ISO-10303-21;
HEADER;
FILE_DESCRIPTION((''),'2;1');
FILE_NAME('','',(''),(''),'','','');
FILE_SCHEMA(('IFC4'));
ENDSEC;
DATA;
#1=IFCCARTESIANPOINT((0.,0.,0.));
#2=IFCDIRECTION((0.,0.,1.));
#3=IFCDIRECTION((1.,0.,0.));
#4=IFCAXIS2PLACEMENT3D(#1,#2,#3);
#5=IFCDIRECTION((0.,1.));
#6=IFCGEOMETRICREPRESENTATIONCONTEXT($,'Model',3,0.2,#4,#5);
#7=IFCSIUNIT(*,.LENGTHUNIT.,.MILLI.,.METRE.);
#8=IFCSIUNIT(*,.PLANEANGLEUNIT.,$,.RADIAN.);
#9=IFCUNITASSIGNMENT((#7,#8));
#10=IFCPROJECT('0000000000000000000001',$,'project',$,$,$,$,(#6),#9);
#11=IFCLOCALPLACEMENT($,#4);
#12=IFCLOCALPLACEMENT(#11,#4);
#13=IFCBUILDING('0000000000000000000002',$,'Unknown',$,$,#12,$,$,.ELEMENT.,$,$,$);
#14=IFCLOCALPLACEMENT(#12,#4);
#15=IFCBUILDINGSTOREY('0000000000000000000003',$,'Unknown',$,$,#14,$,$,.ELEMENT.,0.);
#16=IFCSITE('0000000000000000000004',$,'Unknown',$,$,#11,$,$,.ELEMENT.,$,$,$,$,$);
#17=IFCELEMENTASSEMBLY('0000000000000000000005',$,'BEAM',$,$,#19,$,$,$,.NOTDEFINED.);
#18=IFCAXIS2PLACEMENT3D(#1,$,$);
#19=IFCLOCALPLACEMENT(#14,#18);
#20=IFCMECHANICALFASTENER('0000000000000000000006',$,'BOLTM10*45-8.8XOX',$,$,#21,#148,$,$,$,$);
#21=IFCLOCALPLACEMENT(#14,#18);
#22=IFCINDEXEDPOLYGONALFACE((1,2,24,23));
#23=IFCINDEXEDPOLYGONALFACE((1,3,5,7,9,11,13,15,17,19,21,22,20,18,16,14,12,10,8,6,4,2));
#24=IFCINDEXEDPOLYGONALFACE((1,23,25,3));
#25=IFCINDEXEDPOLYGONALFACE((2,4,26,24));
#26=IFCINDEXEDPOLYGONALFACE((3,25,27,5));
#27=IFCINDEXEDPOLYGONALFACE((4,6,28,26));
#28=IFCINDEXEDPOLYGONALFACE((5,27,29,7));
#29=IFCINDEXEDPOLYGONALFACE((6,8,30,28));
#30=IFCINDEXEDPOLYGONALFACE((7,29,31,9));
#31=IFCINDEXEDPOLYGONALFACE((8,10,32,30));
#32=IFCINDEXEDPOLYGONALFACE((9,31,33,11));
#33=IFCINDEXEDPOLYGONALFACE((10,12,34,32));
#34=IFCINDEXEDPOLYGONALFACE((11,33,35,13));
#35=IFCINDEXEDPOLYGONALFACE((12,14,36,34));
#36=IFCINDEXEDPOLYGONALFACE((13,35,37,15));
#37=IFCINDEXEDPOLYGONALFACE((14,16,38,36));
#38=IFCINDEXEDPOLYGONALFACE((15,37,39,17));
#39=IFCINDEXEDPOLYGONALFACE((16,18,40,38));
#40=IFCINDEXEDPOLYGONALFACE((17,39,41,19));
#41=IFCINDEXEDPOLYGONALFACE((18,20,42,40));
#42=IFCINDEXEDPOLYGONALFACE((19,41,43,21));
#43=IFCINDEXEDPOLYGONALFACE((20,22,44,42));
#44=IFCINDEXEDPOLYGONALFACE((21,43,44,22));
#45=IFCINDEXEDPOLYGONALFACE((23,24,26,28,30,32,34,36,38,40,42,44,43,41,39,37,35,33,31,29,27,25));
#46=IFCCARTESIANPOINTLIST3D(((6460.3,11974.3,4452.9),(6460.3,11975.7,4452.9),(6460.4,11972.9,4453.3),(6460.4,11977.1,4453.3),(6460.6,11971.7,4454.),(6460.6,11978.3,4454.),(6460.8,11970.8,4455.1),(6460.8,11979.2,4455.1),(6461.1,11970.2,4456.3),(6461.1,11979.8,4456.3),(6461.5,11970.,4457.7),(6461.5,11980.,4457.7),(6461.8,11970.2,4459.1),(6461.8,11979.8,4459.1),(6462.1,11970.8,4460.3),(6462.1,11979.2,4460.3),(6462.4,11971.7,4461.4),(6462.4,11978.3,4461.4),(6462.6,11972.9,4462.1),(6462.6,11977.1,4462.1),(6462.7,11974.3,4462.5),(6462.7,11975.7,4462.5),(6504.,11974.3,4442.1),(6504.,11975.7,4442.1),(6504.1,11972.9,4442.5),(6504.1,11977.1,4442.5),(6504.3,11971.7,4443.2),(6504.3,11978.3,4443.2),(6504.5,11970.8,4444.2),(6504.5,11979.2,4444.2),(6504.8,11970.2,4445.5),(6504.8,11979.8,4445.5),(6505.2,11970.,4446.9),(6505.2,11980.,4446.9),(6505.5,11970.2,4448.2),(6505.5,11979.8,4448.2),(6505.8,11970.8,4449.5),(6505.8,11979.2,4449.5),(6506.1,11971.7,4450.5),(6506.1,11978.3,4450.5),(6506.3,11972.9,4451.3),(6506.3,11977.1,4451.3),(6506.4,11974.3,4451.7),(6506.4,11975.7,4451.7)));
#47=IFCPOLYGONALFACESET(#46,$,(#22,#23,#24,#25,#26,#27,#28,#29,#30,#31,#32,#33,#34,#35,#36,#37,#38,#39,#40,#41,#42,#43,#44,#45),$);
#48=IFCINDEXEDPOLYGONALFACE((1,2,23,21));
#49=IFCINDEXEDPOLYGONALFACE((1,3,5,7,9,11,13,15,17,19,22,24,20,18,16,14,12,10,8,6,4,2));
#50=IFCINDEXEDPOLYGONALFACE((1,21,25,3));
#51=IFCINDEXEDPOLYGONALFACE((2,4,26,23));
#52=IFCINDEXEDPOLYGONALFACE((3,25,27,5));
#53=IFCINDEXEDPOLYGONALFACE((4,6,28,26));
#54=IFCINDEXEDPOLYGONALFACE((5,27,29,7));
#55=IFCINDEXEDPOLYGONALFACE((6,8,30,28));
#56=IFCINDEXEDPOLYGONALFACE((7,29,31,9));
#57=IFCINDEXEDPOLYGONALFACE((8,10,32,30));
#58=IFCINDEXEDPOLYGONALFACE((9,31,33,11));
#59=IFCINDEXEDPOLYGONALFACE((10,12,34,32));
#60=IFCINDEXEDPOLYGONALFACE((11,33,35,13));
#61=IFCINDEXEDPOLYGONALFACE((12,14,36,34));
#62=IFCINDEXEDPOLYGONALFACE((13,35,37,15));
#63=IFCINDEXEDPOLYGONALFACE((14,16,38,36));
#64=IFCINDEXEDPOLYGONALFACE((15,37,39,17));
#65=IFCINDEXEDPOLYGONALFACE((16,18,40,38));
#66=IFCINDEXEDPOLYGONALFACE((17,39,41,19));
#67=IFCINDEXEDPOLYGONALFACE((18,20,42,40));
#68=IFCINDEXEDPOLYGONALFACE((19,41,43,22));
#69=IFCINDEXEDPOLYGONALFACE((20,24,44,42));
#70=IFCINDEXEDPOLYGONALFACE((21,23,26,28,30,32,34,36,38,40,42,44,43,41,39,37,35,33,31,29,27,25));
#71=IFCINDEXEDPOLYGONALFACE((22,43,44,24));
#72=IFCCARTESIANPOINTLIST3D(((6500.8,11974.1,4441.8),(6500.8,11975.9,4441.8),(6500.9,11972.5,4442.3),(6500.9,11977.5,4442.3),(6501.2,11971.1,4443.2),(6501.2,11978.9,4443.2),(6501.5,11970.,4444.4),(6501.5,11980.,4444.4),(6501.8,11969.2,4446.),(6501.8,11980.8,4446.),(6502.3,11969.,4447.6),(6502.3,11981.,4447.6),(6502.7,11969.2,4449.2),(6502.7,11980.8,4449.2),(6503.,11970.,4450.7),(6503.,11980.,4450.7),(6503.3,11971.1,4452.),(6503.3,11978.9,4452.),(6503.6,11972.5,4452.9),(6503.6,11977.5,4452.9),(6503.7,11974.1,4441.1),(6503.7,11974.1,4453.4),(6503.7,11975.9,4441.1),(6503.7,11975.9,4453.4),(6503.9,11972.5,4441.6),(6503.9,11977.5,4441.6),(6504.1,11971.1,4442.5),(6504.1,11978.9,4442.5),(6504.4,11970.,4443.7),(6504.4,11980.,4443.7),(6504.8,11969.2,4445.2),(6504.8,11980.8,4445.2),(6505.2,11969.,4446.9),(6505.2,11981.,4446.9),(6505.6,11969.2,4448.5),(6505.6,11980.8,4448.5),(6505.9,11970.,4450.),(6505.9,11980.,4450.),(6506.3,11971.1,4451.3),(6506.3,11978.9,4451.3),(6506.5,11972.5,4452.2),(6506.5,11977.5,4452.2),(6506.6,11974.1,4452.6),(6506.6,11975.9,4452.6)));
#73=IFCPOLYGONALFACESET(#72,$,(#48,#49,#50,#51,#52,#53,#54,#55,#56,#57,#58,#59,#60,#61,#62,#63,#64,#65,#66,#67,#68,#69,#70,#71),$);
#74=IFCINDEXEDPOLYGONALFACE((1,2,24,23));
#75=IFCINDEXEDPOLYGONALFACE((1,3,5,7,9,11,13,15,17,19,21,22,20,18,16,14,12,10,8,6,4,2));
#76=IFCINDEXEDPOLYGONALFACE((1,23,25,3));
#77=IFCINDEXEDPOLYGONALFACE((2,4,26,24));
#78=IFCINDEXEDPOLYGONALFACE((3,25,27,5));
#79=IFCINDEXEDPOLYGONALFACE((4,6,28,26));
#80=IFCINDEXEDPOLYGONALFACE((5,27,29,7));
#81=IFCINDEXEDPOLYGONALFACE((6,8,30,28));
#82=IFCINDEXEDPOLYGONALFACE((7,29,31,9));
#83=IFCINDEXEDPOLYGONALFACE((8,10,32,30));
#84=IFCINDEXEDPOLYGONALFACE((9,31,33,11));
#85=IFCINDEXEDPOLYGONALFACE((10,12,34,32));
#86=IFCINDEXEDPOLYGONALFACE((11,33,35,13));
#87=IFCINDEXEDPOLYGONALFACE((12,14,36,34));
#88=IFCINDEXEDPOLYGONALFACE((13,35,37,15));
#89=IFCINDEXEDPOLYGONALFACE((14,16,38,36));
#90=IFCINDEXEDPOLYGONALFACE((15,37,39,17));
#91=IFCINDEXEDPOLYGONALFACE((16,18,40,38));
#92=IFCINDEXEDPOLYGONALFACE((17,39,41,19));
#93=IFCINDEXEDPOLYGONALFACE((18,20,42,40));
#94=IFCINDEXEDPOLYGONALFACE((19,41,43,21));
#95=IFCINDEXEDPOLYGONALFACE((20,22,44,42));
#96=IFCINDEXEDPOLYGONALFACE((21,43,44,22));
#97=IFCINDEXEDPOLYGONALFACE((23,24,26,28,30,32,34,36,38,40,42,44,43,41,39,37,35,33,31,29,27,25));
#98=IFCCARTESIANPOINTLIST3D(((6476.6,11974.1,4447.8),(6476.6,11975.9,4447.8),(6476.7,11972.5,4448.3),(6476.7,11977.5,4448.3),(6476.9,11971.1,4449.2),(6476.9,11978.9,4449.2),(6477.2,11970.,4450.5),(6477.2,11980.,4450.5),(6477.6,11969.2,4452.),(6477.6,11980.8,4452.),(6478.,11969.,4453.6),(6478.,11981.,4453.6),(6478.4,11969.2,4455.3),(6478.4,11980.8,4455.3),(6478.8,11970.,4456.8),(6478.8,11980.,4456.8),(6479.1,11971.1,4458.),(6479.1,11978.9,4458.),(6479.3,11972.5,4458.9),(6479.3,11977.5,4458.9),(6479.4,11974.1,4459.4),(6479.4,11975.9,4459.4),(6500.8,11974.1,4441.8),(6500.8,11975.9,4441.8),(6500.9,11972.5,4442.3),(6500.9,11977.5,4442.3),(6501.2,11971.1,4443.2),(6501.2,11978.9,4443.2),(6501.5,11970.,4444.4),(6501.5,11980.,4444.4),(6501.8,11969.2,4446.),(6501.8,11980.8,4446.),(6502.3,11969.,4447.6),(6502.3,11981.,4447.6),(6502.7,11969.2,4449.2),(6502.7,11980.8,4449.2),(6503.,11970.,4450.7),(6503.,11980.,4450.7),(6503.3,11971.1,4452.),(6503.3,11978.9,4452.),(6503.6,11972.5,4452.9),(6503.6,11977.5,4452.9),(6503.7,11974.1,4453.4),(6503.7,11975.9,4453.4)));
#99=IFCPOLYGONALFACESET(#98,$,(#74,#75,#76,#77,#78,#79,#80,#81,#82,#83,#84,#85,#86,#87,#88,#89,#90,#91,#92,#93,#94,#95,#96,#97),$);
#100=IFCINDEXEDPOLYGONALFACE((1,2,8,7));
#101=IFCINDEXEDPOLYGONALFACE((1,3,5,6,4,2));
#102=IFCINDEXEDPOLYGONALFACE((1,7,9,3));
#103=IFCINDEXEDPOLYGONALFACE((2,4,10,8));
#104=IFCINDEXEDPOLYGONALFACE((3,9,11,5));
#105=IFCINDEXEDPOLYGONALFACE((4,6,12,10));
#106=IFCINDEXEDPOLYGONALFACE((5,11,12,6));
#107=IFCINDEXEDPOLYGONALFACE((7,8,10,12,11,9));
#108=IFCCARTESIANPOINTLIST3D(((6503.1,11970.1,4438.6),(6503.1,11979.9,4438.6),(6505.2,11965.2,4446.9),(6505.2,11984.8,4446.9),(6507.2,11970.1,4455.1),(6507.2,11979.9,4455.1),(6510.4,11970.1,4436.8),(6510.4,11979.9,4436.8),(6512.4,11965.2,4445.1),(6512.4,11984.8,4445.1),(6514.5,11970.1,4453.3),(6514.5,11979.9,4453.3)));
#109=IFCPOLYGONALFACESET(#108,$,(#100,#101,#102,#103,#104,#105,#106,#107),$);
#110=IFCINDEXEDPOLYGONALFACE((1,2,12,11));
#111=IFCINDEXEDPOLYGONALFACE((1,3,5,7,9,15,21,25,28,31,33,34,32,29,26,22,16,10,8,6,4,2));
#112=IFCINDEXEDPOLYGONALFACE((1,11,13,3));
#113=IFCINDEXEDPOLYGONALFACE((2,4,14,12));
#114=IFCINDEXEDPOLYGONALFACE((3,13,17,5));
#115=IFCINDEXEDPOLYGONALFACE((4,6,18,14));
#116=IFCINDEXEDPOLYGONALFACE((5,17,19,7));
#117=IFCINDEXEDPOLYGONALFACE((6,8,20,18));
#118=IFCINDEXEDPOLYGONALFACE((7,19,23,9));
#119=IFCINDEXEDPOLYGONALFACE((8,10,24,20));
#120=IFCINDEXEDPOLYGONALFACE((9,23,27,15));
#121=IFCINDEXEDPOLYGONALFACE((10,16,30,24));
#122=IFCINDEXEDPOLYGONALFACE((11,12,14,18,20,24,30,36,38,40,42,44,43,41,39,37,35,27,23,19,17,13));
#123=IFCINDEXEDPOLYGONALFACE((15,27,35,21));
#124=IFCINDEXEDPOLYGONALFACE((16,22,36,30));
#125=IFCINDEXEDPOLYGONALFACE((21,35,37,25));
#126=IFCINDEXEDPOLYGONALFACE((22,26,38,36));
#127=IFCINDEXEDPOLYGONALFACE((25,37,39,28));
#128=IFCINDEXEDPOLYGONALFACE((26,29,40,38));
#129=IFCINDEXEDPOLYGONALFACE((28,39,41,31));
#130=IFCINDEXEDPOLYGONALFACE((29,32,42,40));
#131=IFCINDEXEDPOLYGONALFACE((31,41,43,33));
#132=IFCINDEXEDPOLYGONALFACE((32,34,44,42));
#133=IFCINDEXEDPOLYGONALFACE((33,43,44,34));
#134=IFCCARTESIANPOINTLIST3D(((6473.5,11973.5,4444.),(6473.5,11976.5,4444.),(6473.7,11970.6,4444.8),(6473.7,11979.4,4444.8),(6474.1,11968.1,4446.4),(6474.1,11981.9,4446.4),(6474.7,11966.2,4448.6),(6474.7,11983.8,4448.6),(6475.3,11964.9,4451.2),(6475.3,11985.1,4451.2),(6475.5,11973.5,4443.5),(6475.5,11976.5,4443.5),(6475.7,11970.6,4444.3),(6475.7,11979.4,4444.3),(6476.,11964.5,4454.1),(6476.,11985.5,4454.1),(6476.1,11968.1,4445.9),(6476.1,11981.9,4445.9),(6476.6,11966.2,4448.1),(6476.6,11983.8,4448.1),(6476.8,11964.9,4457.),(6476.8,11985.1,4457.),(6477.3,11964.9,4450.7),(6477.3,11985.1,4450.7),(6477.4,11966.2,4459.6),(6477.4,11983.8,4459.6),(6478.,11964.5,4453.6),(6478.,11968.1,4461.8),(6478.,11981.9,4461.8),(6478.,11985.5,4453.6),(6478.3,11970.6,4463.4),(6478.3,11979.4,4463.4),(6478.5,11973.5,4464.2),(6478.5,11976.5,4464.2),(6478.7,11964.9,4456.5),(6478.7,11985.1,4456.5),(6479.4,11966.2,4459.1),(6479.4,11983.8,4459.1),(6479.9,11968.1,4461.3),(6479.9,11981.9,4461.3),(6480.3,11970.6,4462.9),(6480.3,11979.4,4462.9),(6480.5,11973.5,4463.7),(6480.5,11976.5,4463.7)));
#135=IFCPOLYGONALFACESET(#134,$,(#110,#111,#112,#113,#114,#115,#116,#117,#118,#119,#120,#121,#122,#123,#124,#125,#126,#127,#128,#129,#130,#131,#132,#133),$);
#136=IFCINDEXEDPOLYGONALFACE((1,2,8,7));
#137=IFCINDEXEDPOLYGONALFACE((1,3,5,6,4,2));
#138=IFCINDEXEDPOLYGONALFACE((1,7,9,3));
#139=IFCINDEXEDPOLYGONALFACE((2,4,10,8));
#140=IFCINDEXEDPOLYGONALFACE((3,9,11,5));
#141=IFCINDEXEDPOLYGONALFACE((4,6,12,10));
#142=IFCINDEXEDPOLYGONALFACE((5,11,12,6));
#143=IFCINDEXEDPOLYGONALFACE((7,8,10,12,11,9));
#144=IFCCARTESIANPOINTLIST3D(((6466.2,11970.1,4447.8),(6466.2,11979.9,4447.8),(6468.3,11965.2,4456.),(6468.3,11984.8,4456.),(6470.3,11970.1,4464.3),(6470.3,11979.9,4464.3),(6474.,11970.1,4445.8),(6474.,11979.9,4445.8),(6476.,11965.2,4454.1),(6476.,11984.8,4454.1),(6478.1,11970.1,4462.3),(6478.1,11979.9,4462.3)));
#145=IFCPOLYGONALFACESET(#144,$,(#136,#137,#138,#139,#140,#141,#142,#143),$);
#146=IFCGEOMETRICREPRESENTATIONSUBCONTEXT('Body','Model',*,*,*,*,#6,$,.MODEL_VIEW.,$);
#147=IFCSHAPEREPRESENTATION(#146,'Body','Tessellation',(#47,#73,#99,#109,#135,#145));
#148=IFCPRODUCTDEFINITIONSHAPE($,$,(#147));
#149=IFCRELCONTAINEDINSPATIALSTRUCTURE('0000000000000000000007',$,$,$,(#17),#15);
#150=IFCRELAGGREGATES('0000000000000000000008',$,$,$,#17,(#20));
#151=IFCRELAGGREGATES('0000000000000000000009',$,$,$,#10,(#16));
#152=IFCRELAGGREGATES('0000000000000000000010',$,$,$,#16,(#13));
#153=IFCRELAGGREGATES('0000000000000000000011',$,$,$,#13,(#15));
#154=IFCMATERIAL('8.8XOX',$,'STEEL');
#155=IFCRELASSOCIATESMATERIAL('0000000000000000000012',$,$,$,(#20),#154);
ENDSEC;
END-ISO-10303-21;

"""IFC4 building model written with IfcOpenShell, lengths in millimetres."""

from ifc_helpers import new_model, si_unit, direction, frame, origin_with_axes, place, context, subcontext, project, spatial, line, arc, indexed_curve, outline, extrude, source, transform, mapped, material, element, aggregate, save


model = new_model("IFC4")

# Units and contexts
model_context = context("Model", 3, precision=0.2, world=origin_with_axes(), true_north=direction((0.0, 1.0)))
body_context = subcontext(model_context, "Body", "Model", "MODEL_VIEW")
ifc_project = project(units=[si_unit("LENGTHUNIT", "METRE", prefix="MILLI"), si_unit("PLANEANGLEUNIT", "RADIAN")], contexts=[model_context])

# Site, building, storey
site_placement = place(None, origin_with_axes())
site = spatial("IfcSite", under=ifc_project, at=site_placement, Name="Unknown", CompositionType="ELEMENT")
building_placement = place(site_placement, origin_with_axes())
building = spatial("IfcBuilding", under=site, at=building_placement, Name="Unknown", CompositionType="ELEMENT")
storey_placement = place(building_placement, origin_with_axes())
storey = spatial("IfcBuildingStorey", under=building, at=storey_placement, Name="Unknown", CompositionType="ELEMENT", Elevation=0.0)

# Shared definitions
ifc_material_1 = material(Name="8.8XOX", Category="STEEL")

# Element assembly, mechanical fastener
shared_shape_1 = source(origin_with_axes(), body_context, "Body", "SweptSolid", [
    extrude(outline(indexed_curve([(5.0, 0.0), (0.0, 5.0), (-5.0, 0.0), (0.0, -5.0)], segments=[arc(1, 2, 3), arc(3, 4, 1)])), frame((0.0, 0.0, 3.8), z_axis=(0.0, 0.0, -1.0), x_axis=(0.0, 1.0, 0.0)), (0.0, 0.0, 1.0), 45.0),
    extrude(outline(indexed_curve([(6.0, 0.0), (0.0, 6.0), (-6.0, 0.0), (0.0, -6.0)], segments=[arc(1, 2, 3), arc(3, 4, 1)])), frame((0.0, 0.0, 3.8), z_axis=(0.0, 0.0, -1.0), x_axis=(0.0, 1.0, 0.0)), (0.0, 0.0, 1.0), 3.0),
    extrude(outline(indexed_curve([(6.0, 0.0), (0.0, 6.0), (-6.0, 0.0), (0.0, -6.0)], segments=[arc(1, 2, 3), arc(3, 4, 1)])), frame((0.0, 0.0, 0.8), z_axis=(0.0, 0.0, -1.0), x_axis=(0.0, 1.0, 0.0)), (0.0, 0.0, 1.0), 25.0),
    extrude(outline(indexed_curve([(9.8, 0.0), (4.9, 8.5), (-4.9, 8.5), (-9.8, 0.0), (-4.9, -8.5), (4.9, -8.5)], segments=[line(1, 2, 3, 4, 5, 6, 1)])), frame((0.0, 0.0, 11.2), z_axis=(0.0, 0.0, -1.0), x_axis=(0.0, 1.0, 0.0)), (0.0, 0.0, 1.0), 7.5),
    extrude(outline(indexed_curve([(10.5, 0.0), (0.0, 10.5), (-10.5, 0.0), (0.0, -10.5)], segments=[arc(1, 2, 3), arc(3, 4, 1)])), frame((0.0, 0.0, -24.2), z_axis=(0.0, 0.0, -1.0), x_axis=(0.0, 1.0, 0.0)), (0.0, 0.0, 1.0), 2.0),
    extrude(outline(indexed_curve([(9.8, 0.0), (4.9, 8.5), (-4.9, 8.5), (-9.8, 0.0), (-4.9, -8.5), (4.9, -8.5)], segments=[line(1, 2, 3, 4, 5, 6, 1)])), frame((0.0, 0.0, -26.2), z_axis=(0.0, 0.0, -1.0), x_axis=(0.0, 1.0, 0.0)), (0.0, 0.0, 1.0), 8.0),
])
assembly_1_placement = place(storey_placement, frame((6491.3, 6000.0, 4455.5), z_axis=(0.970613, 0.0, -0.240648), x_axis=(0.0, 1.0, 0.0)))
assembly_1 = element("IfcElementAssembly", 1, at=assembly_1_placement, inside=storey, Name="BEAM", PredefinedType="NOTDEFINED")
mechanical_fastener_1_placement = place(assembly_1_placement, frame((5975.0, -5.0, 11.8), z_axis=(0.0, 0.0, 1.0), x_axis=(0.0, 1.0, 0.0)))
mechanical_fastener_1 = element("IfcMechanicalFastener", 2, at=mechanical_fastener_1_placement, material=ifc_material_1, Name="BOLTM10*45-8.8XOX", context=body_context, shape_type="MappedRepresentation", body=[
    mapped(shared_shape_1, transform((0.0, 0.0, 0.0))),
])
aggregate(assembly_1, [mechanical_fastener_1])

save(model, "model.ifc")
